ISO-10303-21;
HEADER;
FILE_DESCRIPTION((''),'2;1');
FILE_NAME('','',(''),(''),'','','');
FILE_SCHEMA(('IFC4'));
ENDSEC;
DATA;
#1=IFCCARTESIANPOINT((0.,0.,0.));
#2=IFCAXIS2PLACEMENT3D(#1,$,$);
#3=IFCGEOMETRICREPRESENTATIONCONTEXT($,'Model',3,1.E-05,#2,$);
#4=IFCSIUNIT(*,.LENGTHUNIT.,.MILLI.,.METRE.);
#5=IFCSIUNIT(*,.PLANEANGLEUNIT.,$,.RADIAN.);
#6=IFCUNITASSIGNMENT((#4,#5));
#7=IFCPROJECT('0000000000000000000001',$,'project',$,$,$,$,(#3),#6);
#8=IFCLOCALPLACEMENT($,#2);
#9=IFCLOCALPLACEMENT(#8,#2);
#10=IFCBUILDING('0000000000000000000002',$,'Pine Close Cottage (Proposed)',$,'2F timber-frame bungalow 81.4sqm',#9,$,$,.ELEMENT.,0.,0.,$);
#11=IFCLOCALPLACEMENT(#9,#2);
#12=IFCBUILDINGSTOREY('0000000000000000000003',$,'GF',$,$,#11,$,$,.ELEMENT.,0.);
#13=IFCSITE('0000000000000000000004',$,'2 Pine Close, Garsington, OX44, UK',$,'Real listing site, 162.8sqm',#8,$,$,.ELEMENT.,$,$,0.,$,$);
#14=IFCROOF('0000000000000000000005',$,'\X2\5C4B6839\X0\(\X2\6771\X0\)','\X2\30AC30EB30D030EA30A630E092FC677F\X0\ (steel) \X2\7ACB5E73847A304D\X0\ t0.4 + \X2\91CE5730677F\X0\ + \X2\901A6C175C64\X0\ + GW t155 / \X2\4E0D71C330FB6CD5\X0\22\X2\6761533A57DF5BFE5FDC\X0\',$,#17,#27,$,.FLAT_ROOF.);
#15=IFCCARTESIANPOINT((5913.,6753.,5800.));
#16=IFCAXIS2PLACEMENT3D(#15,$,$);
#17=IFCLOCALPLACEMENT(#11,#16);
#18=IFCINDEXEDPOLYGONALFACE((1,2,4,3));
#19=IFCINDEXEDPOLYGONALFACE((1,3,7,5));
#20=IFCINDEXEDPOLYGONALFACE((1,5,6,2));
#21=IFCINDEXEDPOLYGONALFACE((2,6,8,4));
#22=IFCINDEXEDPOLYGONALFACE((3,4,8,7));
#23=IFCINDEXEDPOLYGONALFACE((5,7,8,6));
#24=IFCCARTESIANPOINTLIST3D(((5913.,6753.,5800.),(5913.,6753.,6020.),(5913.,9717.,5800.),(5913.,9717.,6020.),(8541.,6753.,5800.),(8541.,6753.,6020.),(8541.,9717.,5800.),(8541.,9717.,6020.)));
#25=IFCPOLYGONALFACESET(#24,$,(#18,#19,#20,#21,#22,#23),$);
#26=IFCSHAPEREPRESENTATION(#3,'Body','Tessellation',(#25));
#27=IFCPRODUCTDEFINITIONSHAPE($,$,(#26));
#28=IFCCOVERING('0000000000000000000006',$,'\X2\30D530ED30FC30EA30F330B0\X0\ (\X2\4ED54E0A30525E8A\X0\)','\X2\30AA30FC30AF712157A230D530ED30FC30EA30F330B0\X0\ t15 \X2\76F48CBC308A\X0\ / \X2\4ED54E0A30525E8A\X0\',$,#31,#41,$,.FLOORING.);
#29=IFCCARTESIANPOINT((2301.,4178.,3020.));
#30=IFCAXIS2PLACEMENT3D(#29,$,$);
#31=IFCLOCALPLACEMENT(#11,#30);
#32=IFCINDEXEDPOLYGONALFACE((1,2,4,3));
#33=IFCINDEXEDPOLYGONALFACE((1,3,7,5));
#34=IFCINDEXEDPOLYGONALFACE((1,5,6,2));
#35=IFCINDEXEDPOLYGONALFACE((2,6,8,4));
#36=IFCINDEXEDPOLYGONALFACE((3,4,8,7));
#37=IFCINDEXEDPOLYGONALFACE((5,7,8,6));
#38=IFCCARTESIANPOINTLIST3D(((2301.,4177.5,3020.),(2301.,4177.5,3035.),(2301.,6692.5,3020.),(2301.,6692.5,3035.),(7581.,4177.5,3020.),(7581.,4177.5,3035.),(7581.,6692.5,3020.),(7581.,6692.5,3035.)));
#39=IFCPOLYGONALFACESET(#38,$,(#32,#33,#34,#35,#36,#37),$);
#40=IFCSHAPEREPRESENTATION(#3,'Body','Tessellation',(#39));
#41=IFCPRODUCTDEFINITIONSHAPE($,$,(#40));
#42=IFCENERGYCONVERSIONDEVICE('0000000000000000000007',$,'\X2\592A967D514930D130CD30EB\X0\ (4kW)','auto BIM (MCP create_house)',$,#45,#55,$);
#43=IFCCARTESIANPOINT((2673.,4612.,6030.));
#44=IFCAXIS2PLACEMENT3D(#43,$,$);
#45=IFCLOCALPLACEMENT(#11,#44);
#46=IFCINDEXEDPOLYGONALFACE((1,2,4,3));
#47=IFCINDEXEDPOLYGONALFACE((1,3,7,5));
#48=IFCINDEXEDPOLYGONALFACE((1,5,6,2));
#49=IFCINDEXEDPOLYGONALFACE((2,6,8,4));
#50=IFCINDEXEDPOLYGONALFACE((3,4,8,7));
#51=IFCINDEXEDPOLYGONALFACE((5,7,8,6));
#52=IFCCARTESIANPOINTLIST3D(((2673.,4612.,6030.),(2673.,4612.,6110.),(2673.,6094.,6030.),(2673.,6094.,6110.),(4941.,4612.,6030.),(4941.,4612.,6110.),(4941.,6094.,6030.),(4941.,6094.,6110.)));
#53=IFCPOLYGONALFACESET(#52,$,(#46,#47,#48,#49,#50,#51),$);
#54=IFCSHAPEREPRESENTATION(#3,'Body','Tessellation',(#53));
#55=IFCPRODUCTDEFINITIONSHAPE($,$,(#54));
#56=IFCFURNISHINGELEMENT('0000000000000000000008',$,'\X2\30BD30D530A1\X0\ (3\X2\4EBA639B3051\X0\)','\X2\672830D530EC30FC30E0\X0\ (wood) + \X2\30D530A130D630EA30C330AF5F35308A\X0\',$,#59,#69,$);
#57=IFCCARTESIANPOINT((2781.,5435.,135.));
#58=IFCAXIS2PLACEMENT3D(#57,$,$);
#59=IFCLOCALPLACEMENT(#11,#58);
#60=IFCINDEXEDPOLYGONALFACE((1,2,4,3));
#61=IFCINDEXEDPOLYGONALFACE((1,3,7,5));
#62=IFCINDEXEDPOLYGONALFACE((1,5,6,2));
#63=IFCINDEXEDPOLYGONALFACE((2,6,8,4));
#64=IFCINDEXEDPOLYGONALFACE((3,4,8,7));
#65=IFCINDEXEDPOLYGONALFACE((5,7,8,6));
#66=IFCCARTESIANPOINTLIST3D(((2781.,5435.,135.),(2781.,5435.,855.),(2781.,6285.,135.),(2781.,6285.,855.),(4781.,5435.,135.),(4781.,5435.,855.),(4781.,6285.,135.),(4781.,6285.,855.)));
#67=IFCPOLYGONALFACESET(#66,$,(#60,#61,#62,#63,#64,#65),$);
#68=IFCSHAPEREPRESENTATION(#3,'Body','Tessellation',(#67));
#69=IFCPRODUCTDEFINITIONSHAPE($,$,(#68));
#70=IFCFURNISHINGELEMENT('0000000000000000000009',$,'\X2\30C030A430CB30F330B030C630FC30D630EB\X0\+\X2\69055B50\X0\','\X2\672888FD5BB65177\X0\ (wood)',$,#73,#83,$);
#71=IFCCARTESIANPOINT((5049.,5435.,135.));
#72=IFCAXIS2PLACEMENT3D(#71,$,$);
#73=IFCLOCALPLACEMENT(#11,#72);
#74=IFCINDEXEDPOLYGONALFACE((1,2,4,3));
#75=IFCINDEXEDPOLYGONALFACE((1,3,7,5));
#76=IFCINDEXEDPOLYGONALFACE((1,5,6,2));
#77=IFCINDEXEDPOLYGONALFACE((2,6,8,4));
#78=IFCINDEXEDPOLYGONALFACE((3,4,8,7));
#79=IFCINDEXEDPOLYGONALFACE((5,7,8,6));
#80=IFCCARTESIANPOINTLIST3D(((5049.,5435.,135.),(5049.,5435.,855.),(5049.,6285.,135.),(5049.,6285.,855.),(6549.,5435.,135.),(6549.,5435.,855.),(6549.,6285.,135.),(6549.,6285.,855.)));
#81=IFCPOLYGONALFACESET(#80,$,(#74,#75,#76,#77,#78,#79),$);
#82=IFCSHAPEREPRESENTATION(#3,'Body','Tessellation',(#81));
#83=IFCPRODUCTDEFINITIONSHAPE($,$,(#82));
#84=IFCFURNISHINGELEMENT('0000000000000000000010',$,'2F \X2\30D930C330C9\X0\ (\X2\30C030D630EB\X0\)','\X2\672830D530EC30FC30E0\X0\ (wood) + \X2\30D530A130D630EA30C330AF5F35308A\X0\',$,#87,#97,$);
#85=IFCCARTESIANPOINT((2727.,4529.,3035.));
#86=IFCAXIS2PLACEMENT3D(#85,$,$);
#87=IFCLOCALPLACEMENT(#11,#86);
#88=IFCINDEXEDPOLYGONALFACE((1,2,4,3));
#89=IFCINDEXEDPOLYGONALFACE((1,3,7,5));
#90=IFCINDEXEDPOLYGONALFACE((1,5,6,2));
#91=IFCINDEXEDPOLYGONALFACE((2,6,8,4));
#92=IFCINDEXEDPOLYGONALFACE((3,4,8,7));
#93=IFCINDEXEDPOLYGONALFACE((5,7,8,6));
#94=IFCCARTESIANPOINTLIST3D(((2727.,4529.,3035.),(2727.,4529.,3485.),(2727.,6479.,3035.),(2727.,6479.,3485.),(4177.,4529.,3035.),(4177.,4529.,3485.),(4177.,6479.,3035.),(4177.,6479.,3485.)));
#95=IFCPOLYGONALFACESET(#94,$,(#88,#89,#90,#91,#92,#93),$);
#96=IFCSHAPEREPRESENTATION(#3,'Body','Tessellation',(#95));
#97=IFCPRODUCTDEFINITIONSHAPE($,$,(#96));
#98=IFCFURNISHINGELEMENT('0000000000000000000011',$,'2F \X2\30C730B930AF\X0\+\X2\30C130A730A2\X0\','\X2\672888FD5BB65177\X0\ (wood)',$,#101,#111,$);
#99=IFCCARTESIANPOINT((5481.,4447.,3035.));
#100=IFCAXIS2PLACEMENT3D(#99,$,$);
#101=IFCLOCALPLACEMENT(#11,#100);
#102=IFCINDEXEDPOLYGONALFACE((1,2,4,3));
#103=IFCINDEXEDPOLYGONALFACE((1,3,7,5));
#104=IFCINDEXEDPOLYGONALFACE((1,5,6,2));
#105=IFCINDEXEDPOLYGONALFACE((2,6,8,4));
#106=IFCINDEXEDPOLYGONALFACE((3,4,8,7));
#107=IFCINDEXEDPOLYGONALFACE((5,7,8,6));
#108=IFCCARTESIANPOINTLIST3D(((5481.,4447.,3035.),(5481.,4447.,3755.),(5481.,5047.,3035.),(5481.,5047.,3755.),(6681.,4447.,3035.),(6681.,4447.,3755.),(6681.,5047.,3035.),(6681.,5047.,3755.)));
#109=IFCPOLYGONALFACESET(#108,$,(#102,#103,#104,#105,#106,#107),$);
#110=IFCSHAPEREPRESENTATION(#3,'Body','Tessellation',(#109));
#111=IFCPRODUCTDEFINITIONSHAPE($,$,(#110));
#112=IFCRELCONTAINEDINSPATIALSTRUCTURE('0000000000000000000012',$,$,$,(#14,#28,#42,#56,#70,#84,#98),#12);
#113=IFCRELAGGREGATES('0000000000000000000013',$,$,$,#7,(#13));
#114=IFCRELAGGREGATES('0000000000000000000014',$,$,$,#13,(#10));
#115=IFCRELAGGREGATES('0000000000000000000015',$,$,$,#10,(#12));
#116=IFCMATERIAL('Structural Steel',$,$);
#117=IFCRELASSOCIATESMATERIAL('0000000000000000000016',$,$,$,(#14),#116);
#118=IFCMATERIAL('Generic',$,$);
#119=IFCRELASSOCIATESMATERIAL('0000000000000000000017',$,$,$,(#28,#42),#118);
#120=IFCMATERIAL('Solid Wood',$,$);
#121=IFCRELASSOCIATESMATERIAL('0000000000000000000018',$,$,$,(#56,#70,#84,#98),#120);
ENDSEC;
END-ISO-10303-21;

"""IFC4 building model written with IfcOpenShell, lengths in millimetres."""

from ifc_helpers import new_model, si_unit, frame, frame_2d, origin, place, context, project, spatial, rectangle, extrude, material, element, save


model = new_model("IFC4")

# Units and contexts
model_context = context("Model", 3, precision=1e-05, world=origin())
ifc_project = project(units=[si_unit("LENGTHUNIT", "METRE", prefix="MILLI"), si_unit("PLANEANGLEUNIT", "RADIAN")], contexts=[model_context])

# Site, building, storey
site_placement = place(None, origin())
site = spatial("IfcSite", under=ifc_project, at=site_placement, Name="2 Pine Close, Garsington, OX44, UK", ObjectType="Real listing site, 162.8sqm", CompositionType="ELEMENT", RefElevation=0.0)
building_placement = place(site_placement, origin())
building = spatial("IfcBuilding", under=site, at=building_placement, Name="Pine Close Cottage (Proposed)", ObjectType="2F timber-frame bungalow 81.4sqm", CompositionType="ELEMENT", ElevationOfRefHeight=0.0, ElevationOfTerrain=0.0)
storey_placement = place(building_placement, origin())
storey = spatial("IfcBuildingStorey", under=building, at=storey_placement, Name="GF", CompositionType="ELEMENT", Elevation=0.0)

# Shared definitions
ifc_material_1 = material(Name="Solid Wood")

# Roof
ifc_material_2 = material(Name="Structural Steel")
roof_1_placement = place(storey_placement, frame((5913.0, 6753.0, 5800.0)))
element("IfcRoof", 1, at=roof_1_placement, inside=storey, material=ifc_material_2, Name="屋根(東)", Description="ガルバリウム鋼板 (steel) 立平葺き t0.4 + 野地板 + 通気層 + GW t155 / 不燃・法22条区域対応", PredefinedType="FLAT_ROOF", context=model_context, shape_type="SweptSolid", body=[
    extrude(rectangle(XDim=2628.0, YDim=2964.0, at=frame_2d((1314.0, 1482.0))), frame((5913.0, 6753.0, 5800.0)), (0.0, 0.0, 1.0), 220.0),
])

# Covering
ifc_material_3 = material(Name="Generic")
covering_placement = place(storey_placement, frame((2301.0, 4178.0, 3020.0)))
element("IfcCovering", 2, at=covering_placement, inside=storey, material=ifc_material_3, Name="フローリング (仕上げ床)", Description="オーク無垢フローリング t15 直貼り / 仕上げ床", PredefinedType="FLOORING", context=model_context, shape_type="SweptSolid", body=[
    extrude(rectangle(XDim=5280.0, YDim=2515.0, at=frame_2d((2640.0, 1257.0))), frame((2301.0, 4178.0, 3020.0)), (0.0, 0.0, 1.0), 15.0),
])

# Energy conversion device
energy_conversion_device_placement = place(storey_placement, frame((2673.0, 4612.0, 6030.0)))
element("IfcEnergyConversionDevice", 3, at=energy_conversion_device_placement, inside=storey, material=ifc_material_3, Name="太陽光パネル (4kW)", Description="auto BIM (MCP create_house)", context=model_context, shape_type="SweptSolid", body=[
    extrude(rectangle(XDim=2268.0, YDim=1482.0, at=frame_2d((1134.0, 741.0))), frame((2673.0, 4612.0, 6030.0)), (0.0, 0.0, 1.0), 80.0),
])

# Furnishing elements
furnishing_1_placement = place(storey_placement, frame((2781.0, 5435.0, 135.0)))
element("IfcFurnishingElement", 4, at=furnishing_1_placement, inside=storey, material=ifc_material_1, Name="ソファ (3人掛け)", Description="木フレーム (wood) + ファブリック張り", context=model_context, shape_type="SweptSolid", body=[
    extrude(rectangle(XDim=2000.0, YDim=850.0, at=frame_2d((1000.0, 425.0))), frame((2781.0, 5435.0, 135.0)), (0.0, 0.0, 1.0), 720.0),
])
furnishing_2_placement = place(storey_placement, frame((5049.0, 5435.0, 135.0)))
element("IfcFurnishingElement", 5, at=furnishing_2_placement, inside=storey, material=ifc_material_1, Name="ダイニングテーブル+椅子", Description="木製家具 (wood)", context=model_context, shape_type="SweptSolid", body=[
    extrude(rectangle(XDim=1500.0, YDim=850.0, at=frame_2d((750.0, 425.0))), frame((5049.0, 5435.0, 135.0)), (0.0, 0.0, 1.0), 720.0),
])
furnishing_3_placement = place(storey_placement, frame((2727.0, 4529.0, 3035.0)))
element("IfcFurnishingElement", 6, at=furnishing_3_placement, inside=storey, material=ifc_material_1, Name="2F ベッド (ダブル)", Description="木フレーム (wood) + ファブリック張り", context=model_context, shape_type="SweptSolid", body=[
    extrude(rectangle(XDim=1450.0, YDim=1950.0, at=frame_2d((725.0, 975.0))), frame((2727.0, 4529.0, 3035.0)), (0.0, 0.0, 1.0), 450.0),
])
furnishing_4_placement = place(storey_placement, frame((5481.0, 4447.0, 3035.0)))
element("IfcFurnishingElement", 7, at=furnishing_4_placement, inside=storey, material=ifc_material_1, Name="2F デスク+チェア", Description="木製家具 (wood)", context=model_context, shape_type="SweptSolid", body=[
    extrude(rectangle(XDim=1200.0, YDim=600.0, at=frame_2d((600.0, 300.0))), frame((5481.0, 4447.0, 3035.0)), (0.0, 0.0, 1.0), 720.0),
])

save(model, "model.ifc")
